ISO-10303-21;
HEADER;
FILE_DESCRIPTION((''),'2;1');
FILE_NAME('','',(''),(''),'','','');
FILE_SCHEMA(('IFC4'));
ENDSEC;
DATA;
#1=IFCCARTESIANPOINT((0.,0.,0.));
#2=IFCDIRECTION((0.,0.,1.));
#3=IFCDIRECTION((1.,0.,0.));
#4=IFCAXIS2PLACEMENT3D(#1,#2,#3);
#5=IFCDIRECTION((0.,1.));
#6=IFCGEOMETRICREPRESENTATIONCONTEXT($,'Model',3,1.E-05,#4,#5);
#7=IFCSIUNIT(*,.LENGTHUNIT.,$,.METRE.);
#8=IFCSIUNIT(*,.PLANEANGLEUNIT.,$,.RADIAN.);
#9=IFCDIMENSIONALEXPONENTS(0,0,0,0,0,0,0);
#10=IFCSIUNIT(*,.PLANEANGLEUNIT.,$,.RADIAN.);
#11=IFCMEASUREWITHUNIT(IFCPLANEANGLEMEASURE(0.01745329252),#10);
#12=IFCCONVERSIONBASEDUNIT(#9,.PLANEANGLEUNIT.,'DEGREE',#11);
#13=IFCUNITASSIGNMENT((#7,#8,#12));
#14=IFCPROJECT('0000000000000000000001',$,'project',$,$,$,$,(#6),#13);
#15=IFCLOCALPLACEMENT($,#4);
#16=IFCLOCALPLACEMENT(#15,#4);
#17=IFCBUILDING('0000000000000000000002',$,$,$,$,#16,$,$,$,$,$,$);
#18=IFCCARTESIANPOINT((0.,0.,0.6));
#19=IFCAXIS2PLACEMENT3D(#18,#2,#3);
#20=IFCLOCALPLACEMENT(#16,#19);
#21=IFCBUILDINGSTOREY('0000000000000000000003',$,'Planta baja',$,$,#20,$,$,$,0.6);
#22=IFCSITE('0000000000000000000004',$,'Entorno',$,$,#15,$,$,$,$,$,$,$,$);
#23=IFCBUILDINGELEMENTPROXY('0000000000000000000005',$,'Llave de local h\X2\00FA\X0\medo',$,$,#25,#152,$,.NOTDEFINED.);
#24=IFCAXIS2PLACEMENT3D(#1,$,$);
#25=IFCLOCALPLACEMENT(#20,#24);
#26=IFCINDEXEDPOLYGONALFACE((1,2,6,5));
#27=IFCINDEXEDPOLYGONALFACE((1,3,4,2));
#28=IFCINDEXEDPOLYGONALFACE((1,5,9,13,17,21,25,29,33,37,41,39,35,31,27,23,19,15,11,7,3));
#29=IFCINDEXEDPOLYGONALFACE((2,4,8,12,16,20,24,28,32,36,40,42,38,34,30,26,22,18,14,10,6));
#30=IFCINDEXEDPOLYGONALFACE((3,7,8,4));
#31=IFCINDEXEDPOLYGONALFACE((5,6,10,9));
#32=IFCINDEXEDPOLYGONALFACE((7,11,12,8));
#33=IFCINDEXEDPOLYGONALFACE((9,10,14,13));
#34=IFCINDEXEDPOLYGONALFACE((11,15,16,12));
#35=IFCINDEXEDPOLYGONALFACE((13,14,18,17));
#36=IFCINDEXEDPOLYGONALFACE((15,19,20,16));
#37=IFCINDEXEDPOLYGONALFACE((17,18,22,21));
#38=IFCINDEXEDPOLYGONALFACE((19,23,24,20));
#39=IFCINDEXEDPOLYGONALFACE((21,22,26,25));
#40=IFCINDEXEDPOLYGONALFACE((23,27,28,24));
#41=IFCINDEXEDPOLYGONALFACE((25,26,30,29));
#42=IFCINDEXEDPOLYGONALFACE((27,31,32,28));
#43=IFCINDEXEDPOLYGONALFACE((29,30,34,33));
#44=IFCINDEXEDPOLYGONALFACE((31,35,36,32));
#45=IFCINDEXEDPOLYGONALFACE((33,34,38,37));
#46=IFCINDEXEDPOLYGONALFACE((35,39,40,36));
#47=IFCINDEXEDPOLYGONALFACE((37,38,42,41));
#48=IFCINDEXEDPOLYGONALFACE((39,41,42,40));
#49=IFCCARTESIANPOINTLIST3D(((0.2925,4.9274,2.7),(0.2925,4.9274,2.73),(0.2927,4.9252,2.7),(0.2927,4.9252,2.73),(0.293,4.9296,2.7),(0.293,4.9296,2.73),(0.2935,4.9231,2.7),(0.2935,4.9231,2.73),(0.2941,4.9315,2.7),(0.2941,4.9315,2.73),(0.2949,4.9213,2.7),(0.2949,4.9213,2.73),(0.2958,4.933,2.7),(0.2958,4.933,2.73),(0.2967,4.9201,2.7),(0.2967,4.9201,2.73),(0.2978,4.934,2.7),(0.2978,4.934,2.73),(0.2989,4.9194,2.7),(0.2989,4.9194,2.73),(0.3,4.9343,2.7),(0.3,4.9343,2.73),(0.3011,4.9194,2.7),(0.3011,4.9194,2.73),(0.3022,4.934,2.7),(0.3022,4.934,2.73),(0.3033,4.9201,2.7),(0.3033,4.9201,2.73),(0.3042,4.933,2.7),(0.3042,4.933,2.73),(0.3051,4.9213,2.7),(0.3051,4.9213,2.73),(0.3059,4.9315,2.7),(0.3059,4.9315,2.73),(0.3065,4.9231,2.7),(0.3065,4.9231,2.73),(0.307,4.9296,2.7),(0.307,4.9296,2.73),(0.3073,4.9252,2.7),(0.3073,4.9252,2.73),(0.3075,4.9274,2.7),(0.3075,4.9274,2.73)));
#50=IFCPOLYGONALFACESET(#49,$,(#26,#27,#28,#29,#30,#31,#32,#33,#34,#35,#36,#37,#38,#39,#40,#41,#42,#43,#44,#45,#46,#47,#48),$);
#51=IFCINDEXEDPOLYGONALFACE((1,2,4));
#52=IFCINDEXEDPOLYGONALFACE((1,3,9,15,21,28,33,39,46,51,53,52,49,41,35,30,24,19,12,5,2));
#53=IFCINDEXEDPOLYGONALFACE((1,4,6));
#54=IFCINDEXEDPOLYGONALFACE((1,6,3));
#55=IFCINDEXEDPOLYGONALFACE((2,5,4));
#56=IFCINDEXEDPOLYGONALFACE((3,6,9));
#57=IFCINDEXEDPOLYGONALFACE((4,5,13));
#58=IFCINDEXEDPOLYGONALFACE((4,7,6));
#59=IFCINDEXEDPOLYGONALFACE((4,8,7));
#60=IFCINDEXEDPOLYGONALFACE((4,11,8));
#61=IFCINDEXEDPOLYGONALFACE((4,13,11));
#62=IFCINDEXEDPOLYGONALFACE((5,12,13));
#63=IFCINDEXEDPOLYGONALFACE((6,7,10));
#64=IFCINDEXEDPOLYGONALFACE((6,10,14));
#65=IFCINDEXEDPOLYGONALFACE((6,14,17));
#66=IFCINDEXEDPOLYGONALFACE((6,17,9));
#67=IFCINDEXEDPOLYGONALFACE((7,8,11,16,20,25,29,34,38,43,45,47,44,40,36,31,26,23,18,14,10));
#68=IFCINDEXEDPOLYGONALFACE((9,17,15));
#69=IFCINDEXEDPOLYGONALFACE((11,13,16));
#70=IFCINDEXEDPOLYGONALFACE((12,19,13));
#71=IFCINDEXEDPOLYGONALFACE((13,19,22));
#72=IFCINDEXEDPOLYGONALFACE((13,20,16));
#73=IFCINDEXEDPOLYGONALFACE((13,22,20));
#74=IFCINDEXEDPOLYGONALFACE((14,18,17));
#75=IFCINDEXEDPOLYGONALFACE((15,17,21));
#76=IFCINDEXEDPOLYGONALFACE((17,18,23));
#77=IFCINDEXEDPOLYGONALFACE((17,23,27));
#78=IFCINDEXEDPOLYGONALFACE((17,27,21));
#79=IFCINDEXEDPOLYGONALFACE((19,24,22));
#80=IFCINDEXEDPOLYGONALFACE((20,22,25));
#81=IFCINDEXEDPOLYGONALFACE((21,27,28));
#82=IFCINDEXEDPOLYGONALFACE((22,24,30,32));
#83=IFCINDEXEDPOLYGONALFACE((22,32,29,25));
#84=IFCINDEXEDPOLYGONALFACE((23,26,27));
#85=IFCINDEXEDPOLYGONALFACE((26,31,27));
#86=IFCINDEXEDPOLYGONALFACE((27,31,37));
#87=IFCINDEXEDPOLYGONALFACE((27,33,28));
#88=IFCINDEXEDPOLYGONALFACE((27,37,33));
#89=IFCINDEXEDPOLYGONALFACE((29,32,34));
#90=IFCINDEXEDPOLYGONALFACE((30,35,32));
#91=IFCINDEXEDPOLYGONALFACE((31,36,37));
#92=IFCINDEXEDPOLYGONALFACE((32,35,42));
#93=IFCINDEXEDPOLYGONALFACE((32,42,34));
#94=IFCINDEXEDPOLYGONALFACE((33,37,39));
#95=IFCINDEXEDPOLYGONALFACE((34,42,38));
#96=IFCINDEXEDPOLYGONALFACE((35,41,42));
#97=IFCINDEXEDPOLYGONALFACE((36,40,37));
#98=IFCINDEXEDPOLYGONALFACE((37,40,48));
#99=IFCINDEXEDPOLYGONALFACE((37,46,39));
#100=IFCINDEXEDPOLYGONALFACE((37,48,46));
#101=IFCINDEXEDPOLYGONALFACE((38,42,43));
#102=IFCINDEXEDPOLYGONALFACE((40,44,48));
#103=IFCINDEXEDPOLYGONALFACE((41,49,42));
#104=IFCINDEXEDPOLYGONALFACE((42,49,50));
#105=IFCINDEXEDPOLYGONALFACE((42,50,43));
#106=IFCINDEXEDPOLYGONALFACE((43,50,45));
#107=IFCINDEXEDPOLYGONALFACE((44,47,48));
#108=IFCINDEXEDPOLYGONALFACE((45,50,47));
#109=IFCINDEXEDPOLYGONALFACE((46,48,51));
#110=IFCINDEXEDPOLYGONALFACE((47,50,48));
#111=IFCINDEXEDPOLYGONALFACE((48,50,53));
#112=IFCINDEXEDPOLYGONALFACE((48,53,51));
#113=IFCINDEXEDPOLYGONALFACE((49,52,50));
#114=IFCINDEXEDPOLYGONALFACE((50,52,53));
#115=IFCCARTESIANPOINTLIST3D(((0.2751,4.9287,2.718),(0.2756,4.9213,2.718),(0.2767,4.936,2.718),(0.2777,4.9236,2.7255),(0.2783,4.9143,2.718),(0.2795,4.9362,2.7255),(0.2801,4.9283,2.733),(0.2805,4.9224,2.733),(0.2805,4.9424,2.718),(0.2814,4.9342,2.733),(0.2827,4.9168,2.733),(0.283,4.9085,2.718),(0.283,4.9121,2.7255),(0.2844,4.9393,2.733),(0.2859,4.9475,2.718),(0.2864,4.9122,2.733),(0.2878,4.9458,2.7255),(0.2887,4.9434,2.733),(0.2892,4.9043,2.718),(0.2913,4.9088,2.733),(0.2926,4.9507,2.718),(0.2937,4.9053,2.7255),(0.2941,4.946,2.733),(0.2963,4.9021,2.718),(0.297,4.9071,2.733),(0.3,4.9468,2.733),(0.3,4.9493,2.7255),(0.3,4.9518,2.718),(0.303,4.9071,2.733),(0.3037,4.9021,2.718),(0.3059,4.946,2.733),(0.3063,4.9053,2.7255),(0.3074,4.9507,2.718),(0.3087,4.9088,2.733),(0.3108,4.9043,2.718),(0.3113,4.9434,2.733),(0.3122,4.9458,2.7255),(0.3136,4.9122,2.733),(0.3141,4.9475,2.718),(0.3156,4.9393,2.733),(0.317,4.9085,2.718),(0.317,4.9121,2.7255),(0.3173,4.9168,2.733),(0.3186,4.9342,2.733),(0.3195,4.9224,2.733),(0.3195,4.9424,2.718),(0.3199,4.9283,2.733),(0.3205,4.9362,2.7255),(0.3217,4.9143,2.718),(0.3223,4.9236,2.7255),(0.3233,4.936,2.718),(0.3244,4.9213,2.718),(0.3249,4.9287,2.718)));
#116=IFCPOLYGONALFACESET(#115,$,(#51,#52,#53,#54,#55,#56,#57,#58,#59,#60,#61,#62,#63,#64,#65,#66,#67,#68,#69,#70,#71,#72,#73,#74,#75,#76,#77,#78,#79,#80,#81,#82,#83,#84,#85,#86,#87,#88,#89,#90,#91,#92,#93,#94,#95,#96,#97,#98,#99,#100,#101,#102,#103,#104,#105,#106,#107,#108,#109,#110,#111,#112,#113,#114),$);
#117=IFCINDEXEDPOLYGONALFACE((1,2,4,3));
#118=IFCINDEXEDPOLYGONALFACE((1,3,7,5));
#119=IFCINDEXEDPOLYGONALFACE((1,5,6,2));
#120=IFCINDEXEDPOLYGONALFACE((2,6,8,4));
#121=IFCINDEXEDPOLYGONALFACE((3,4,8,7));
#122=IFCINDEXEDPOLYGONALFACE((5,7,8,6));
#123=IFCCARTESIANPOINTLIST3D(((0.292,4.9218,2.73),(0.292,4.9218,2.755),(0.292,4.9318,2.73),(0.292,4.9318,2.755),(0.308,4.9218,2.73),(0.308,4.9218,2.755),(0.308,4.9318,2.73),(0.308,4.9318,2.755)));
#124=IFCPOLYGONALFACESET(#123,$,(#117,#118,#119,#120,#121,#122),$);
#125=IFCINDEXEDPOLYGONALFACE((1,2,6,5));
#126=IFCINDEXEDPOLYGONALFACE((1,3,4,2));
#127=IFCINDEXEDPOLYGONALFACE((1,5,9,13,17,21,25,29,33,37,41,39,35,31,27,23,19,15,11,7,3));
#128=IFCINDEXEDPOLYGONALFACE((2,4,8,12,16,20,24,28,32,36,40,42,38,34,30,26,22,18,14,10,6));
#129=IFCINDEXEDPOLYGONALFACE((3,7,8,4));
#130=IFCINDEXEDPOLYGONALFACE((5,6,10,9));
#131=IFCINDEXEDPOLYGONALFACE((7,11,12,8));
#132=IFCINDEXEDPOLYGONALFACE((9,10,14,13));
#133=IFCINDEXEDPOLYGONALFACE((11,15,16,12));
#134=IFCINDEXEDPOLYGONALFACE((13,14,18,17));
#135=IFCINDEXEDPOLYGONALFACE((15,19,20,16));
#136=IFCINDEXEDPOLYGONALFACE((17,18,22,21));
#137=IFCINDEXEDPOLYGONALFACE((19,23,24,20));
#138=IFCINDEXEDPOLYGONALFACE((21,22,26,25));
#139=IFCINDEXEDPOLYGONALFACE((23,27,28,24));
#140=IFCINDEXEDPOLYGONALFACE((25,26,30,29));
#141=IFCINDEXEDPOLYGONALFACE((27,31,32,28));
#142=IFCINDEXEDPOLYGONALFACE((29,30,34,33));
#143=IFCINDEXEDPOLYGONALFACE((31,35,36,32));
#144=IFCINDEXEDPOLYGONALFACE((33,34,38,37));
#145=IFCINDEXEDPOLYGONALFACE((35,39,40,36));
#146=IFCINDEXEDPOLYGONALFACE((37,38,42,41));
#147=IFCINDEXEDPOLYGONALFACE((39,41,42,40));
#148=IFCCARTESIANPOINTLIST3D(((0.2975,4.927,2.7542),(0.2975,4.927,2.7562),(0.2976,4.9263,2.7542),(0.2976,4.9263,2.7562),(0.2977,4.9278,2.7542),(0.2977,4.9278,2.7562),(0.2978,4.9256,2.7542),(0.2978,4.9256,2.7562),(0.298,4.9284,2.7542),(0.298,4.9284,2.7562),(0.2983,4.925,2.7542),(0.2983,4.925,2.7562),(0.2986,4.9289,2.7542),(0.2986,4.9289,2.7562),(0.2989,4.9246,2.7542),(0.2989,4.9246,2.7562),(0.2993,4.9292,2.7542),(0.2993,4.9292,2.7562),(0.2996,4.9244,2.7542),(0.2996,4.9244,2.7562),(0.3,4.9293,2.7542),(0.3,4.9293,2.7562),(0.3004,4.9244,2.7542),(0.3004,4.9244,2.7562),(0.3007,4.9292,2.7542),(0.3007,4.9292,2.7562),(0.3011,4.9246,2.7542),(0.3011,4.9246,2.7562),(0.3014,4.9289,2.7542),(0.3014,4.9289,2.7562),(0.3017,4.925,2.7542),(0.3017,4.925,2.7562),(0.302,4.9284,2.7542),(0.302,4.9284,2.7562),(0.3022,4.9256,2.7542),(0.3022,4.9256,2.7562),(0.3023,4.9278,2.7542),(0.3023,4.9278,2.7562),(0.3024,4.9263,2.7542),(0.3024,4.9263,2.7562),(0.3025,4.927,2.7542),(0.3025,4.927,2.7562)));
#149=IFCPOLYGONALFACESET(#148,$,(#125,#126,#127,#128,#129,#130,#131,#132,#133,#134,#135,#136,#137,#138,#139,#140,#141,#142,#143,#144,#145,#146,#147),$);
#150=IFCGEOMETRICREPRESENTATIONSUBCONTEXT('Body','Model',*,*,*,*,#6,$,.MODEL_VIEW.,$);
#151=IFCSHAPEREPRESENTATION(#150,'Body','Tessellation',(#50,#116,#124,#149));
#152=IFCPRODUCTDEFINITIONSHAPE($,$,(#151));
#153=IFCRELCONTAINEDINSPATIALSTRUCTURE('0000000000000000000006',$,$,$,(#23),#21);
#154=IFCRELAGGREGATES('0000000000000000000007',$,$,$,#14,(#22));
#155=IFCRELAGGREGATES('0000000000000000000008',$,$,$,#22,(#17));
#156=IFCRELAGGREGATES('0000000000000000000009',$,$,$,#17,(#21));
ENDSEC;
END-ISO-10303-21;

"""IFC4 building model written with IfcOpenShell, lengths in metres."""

from ifc_helpers import new_model, entity, si_unit, converted_unit, direction, frame, origin_with_axes, place, context, subcontext, project, spatial, polyline, outline, extrude, element, save


model = new_model("IFC4")

# Units and contexts
model_context = context("Model", 3, precision=1e-05, world=origin_with_axes(), true_north=direction((0.0, 1.0)))
body_context = subcontext(model_context, "Body", "Model", "MODEL_VIEW")
ifc_project = project(units=[si_unit("LENGTHUNIT", "METRE"), si_unit("PLANEANGLEUNIT", "RADIAN"), converted_unit("PLANEANGLEUNIT", "DEGREE", entity("IfcPlaneAngleMeasure", 0.01745329252), si_unit("PLANEANGLEUNIT", "RADIAN"), dimensions=[0, 0, 0, 0, 0, 0, 0])], contexts=[model_context])

# Site, building, storey
site_placement = place(None, origin_with_axes())
site = spatial("IfcSite", under=ifc_project, at=site_placement, Name="Entorno")
building_placement = place(site_placement, origin_with_axes())
building = spatial("IfcBuilding", under=site, at=building_placement)
storey_placement = place(building_placement, frame((0.0, 0.0, 0.6), z_axis=(0.0, 0.0, 1.0), x_axis=(1.0, 0.0, 0.0)))
storey = spatial("IfcBuildingStorey", under=building, at=storey_placement, Name="Planta baja", Elevation=0.6)

# Building element proxy
proxy_1_placement = place(storey_placement, frame((0.0, 0.0, -0.6), z_axis=(0.0, 0.0, 1.0), x_axis=(1.0, 0.0, 0.0)))
ifc_direction_1 = entity("IfcDirection", [0.0, 0.0, 1.0])
ifc_direction_2 = entity("IfcDirection", [0.0, 0.0, 1.0])
ifc_direction_3 = entity("IfcDirection", [0.0, 0.0, 1.0])
element("IfcBuildingElementProxy", 1, at=proxy_1_placement, inside=storey, Name="Llave de local húmedo", PredefinedType="NOTDEFINED", context=body_context, shape_type="Brep", body=[
    entity("IfcExtrudedAreaSolidTapered", entity("IfcCircleProfileDef", "AREA", None, entity("IfcAxis2Placement2D", entity("IfcCartesianPoint", [0.0, 0.0]), entity("IfcDirection", [1.0, 0.0])), 0.0075), entity("IfcAxis2Placement3D", entity("IfcCartesianPoint", [0.3, 4.9268, 3.3]), ifc_direction_1, entity("IfcDirection", [0.0, 1.0, 0.0])), ifc_direction_1, 0.03, entity("IfcCircleProfileDef", "AREA", None, entity("IfcAxis2Placement2D", entity("IfcCartesianPoint", [0.0, 0.0]), entity("IfcDirection", [1.0, 0.0])), 0.0075)),
    entity("IfcExtrudedAreaSolidTapered", entity("IfcCircleProfileDef", "AREA", None, entity("IfcAxis2Placement2D", entity("IfcCartesianPoint", [0.0, 0.0]), entity("IfcDirection", [1.0, 0.0])), 0.025), entity("IfcAxis2Placement3D", entity("IfcCartesianPoint", [0.3, 4.9268, 3.318]), ifc_direction_2, entity("IfcDirection", [0.0, 1.0, 0.0])), ifc_direction_2, 0.015, entity("IfcCircleProfileDef", "AREA", None, entity("IfcAxis2Placement2D", entity("IfcCartesianPoint", [0.0, 0.0]), entity("IfcDirection", [1.0, 0.0])), 0.02)),
    extrude(outline(polyline([(0.005, -0.008), (0.005, 0.008), (-0.005, 0.008), (-0.005, -0.008), (0.005, -0.008)])), frame((0.3, 4.9268, 3.33), z_axis=(0.0, 0.0, 1.0), x_axis=(0.0, 1.0, 0.0)), (0.0, 0.0, 1.0), 0.025),
    entity("IfcExtrudedAreaSolidTapered", entity("IfcCircleProfileDef", "AREA", None, entity("IfcAxis2Placement2D", entity("IfcCartesianPoint", [0.0, 0.0]), entity("IfcDirection", [1.0, 0.0])), 0.0025), entity("IfcAxis2Placement3D", entity("IfcCartesianPoint", [0.3, 4.9268, 3.3542]), ifc_direction_3, entity("IfcDirection", [0.0, 1.0, 0.0])), ifc_direction_3, 0.002, entity("IfcCircleProfileDef", "AREA", None, entity("IfcAxis2Placement2D", entity("IfcCartesianPoint", [0.0, 0.0]), entity("IfcDirection", [1.0, 0.0])), 0.0025)),
])

save(model, "model.ifc")
